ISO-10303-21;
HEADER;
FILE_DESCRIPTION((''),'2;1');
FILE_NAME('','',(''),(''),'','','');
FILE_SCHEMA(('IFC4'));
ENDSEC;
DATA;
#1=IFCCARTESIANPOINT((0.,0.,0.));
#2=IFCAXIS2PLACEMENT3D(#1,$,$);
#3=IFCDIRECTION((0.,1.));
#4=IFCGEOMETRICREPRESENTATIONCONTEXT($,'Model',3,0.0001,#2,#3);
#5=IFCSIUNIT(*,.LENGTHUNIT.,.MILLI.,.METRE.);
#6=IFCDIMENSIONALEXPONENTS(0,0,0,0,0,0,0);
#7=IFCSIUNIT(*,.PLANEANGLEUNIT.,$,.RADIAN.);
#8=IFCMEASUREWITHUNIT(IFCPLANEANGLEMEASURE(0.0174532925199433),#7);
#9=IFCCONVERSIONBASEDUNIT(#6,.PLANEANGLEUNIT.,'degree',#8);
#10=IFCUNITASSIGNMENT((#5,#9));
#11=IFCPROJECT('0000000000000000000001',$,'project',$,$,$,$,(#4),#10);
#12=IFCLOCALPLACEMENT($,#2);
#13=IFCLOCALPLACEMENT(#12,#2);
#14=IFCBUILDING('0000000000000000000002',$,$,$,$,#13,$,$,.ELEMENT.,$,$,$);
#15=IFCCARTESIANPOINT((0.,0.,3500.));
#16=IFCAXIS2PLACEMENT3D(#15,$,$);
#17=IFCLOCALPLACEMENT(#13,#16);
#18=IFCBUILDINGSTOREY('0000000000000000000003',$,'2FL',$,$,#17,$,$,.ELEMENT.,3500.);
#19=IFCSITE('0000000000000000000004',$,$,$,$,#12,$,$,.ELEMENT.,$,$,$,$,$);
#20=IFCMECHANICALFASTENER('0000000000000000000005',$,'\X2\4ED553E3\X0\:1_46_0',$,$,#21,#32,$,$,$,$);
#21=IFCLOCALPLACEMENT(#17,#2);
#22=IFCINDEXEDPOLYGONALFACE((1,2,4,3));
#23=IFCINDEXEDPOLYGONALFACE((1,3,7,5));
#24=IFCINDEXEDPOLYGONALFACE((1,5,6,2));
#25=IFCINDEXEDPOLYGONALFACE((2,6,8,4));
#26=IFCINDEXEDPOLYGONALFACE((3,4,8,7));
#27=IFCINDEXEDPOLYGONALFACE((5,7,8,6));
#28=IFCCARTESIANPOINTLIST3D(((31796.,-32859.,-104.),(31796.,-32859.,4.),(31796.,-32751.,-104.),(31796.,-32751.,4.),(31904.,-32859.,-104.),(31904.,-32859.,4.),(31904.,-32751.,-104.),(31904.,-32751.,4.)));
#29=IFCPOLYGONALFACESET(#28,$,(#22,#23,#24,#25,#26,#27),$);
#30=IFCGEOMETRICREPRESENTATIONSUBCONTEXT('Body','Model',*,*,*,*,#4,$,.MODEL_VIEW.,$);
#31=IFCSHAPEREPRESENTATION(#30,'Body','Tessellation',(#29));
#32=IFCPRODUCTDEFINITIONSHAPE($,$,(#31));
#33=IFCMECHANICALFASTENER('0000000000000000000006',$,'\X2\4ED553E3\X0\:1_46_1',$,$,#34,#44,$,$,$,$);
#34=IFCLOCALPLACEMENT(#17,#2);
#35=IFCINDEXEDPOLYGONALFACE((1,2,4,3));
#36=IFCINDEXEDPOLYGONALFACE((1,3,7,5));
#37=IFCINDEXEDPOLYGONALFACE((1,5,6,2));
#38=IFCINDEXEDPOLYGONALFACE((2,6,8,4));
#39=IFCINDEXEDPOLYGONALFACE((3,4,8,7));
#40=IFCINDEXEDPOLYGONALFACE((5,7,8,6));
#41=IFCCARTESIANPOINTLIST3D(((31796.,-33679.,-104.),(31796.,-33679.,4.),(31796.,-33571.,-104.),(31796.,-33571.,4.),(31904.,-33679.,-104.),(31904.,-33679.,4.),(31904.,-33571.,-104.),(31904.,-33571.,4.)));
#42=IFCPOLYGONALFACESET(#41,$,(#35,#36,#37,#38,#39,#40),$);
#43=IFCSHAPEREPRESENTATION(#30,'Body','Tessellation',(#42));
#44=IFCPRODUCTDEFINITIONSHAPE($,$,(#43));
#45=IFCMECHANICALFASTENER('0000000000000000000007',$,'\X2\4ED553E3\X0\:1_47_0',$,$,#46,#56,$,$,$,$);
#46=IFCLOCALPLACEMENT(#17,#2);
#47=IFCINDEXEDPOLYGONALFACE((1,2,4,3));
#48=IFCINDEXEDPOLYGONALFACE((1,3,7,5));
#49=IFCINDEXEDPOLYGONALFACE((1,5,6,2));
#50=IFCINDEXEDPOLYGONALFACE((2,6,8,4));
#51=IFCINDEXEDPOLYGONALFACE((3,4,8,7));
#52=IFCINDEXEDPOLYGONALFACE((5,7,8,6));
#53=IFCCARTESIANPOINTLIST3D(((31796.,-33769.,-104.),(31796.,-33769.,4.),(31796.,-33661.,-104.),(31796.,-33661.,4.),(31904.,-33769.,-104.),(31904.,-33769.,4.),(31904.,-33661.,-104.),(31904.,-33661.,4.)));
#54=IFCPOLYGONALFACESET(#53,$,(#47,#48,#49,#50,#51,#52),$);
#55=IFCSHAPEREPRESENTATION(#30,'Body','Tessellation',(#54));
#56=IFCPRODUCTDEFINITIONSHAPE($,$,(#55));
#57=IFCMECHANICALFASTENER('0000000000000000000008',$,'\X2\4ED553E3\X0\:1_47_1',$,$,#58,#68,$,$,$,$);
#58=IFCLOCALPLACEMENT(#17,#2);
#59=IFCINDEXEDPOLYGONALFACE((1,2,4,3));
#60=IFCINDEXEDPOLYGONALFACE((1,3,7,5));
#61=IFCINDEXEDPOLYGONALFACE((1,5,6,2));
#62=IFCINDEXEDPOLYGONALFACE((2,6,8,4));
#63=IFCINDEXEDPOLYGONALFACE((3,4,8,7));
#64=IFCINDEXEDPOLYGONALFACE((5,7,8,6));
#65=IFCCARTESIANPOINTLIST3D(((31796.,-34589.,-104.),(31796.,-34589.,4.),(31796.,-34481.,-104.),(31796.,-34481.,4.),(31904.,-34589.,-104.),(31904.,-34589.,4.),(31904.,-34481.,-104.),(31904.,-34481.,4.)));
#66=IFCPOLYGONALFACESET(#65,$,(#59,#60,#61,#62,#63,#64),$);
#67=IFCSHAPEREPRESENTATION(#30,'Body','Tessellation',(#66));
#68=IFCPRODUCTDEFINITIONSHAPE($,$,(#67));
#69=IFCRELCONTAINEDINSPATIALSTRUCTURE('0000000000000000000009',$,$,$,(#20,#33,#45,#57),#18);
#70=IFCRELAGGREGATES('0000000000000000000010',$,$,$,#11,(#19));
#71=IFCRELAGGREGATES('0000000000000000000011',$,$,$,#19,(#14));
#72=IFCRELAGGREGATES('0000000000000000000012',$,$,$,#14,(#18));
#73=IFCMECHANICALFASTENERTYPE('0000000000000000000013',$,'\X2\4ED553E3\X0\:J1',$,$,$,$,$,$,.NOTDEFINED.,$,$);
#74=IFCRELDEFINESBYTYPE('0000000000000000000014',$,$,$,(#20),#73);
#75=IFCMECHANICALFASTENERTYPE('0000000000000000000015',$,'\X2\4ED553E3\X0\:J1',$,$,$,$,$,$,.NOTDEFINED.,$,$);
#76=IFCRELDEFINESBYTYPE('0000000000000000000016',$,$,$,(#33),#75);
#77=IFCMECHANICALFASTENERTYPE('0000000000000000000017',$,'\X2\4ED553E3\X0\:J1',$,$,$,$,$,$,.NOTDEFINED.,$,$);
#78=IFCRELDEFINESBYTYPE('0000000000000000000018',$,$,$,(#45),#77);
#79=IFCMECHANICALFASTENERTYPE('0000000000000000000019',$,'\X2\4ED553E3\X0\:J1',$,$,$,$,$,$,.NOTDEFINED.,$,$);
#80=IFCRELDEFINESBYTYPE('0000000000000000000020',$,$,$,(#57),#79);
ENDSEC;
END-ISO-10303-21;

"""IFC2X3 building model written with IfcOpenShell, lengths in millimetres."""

from ifc_helpers import new_model, entity, si_unit, converted_unit, direction, frame, origin, origin_with_axes, origin_2d, place, context, subcontext, project, spatial, rectangle, extrude, type_object, element, save


model = new_model("IFC2X3")

# Units and contexts
model_context = context("Model", 3, precision=0.0001, world=origin(), true_north=direction((0.0, 1.0)))
body_context = subcontext(model_context, "Body", "Model", "MODEL_VIEW")
ifc_project = project(units=[si_unit("LENGTHUNIT", "METRE", prefix="MILLI"), converted_unit("PLANEANGLEUNIT", "degree", entity("IfcPlaneAngleMeasure", 0.0174532925199433), si_unit("PLANEANGLEUNIT", "RADIAN"), dimensions=[0, 0, 0, 0, 0, 0, 0])], contexts=[model_context])

# Site, building, storey
site_placement = place(None, origin())
site = spatial("IfcSite", under=ifc_project, at=site_placement, CompositionType="ELEMENT")
building_placement = place(site_placement, origin())
building = spatial("IfcBuilding", under=site, at=building_placement, CompositionType="ELEMENT")
storey_placement = place(building_placement, frame((0.0, 0.0, 3500.0)))
storey = spatial("IfcBuildingStorey", under=building, at=storey_placement, Name="2FL", CompositionType="ELEMENT", Elevation=3500.0)

# Mechanical fasteners
mechanical_fastener_type_1 = type_object("IfcMechanicalFastenerType", Name="仕口:J1")
mechanical_fastener_1_placement = place(storey_placement, frame((31850.0, -32805.0, -104.0)))
element("IfcMechanicalFastener", 1, at=mechanical_fastener_1_placement, inside=storey, type_object=mechanical_fastener_type_1, Name="仕口:1_46_0", context=body_context, shape_type="SweptSolid", body=[
    extrude(rectangle(XDim=108.0, YDim=108.0, at=origin_2d()), origin_with_axes(), (0.0, 0.0, 1.0), 108.0),
])
mechanical_fastener_type_2 = type_object("IfcMechanicalFastenerType", Name="仕口:J1")
mechanical_fastener_2_placement = place(storey_placement, frame((31850.0, -33625.0, -104.0)))
element("IfcMechanicalFastener", 2, at=mechanical_fastener_2_placement, inside=storey, type_object=mechanical_fastener_type_2, Name="仕口:1_46_1", context=body_context, shape_type="SweptSolid", body=[
    extrude(rectangle(XDim=108.0, YDim=108.0, at=origin_2d()), origin_with_axes(), (0.0, 0.0, 1.0), 108.0),
])
mechanical_fastener_type_3 = type_object("IfcMechanicalFastenerType", Name="仕口:J1")
mechanical_fastener_3_placement = place(storey_placement, frame((31850.0, -33715.0, -104.0)))
element("IfcMechanicalFastener", 3, at=mechanical_fastener_3_placement, inside=storey, type_object=mechanical_fastener_type_3, Name="仕口:1_47_0", context=body_context, shape_type="SweptSolid", body=[
    extrude(rectangle(XDim=108.0, YDim=108.0, at=origin_2d()), origin_with_axes(), (0.0, 0.0, 1.0), 108.0),
])
mechanical_fastener_type_4 = type_object("IfcMechanicalFastenerType", Name="仕口:J1")
mechanical_fastener_4_placement = place(storey_placement, frame((31850.0, -34535.0, -104.0)))
element("IfcMechanicalFastener", 4, at=mechanical_fastener_4_placement, inside=storey, type_object=mechanical_fastener_type_4, Name="仕口:1_47_1", context=body_context, shape_type="SweptSolid", body=[
    extrude(rectangle(XDim=108.0, YDim=108.0, at=origin_2d()), origin_with_axes(), (0.0, 0.0, 1.0), 108.0),
])

save(model, "model.ifc")
